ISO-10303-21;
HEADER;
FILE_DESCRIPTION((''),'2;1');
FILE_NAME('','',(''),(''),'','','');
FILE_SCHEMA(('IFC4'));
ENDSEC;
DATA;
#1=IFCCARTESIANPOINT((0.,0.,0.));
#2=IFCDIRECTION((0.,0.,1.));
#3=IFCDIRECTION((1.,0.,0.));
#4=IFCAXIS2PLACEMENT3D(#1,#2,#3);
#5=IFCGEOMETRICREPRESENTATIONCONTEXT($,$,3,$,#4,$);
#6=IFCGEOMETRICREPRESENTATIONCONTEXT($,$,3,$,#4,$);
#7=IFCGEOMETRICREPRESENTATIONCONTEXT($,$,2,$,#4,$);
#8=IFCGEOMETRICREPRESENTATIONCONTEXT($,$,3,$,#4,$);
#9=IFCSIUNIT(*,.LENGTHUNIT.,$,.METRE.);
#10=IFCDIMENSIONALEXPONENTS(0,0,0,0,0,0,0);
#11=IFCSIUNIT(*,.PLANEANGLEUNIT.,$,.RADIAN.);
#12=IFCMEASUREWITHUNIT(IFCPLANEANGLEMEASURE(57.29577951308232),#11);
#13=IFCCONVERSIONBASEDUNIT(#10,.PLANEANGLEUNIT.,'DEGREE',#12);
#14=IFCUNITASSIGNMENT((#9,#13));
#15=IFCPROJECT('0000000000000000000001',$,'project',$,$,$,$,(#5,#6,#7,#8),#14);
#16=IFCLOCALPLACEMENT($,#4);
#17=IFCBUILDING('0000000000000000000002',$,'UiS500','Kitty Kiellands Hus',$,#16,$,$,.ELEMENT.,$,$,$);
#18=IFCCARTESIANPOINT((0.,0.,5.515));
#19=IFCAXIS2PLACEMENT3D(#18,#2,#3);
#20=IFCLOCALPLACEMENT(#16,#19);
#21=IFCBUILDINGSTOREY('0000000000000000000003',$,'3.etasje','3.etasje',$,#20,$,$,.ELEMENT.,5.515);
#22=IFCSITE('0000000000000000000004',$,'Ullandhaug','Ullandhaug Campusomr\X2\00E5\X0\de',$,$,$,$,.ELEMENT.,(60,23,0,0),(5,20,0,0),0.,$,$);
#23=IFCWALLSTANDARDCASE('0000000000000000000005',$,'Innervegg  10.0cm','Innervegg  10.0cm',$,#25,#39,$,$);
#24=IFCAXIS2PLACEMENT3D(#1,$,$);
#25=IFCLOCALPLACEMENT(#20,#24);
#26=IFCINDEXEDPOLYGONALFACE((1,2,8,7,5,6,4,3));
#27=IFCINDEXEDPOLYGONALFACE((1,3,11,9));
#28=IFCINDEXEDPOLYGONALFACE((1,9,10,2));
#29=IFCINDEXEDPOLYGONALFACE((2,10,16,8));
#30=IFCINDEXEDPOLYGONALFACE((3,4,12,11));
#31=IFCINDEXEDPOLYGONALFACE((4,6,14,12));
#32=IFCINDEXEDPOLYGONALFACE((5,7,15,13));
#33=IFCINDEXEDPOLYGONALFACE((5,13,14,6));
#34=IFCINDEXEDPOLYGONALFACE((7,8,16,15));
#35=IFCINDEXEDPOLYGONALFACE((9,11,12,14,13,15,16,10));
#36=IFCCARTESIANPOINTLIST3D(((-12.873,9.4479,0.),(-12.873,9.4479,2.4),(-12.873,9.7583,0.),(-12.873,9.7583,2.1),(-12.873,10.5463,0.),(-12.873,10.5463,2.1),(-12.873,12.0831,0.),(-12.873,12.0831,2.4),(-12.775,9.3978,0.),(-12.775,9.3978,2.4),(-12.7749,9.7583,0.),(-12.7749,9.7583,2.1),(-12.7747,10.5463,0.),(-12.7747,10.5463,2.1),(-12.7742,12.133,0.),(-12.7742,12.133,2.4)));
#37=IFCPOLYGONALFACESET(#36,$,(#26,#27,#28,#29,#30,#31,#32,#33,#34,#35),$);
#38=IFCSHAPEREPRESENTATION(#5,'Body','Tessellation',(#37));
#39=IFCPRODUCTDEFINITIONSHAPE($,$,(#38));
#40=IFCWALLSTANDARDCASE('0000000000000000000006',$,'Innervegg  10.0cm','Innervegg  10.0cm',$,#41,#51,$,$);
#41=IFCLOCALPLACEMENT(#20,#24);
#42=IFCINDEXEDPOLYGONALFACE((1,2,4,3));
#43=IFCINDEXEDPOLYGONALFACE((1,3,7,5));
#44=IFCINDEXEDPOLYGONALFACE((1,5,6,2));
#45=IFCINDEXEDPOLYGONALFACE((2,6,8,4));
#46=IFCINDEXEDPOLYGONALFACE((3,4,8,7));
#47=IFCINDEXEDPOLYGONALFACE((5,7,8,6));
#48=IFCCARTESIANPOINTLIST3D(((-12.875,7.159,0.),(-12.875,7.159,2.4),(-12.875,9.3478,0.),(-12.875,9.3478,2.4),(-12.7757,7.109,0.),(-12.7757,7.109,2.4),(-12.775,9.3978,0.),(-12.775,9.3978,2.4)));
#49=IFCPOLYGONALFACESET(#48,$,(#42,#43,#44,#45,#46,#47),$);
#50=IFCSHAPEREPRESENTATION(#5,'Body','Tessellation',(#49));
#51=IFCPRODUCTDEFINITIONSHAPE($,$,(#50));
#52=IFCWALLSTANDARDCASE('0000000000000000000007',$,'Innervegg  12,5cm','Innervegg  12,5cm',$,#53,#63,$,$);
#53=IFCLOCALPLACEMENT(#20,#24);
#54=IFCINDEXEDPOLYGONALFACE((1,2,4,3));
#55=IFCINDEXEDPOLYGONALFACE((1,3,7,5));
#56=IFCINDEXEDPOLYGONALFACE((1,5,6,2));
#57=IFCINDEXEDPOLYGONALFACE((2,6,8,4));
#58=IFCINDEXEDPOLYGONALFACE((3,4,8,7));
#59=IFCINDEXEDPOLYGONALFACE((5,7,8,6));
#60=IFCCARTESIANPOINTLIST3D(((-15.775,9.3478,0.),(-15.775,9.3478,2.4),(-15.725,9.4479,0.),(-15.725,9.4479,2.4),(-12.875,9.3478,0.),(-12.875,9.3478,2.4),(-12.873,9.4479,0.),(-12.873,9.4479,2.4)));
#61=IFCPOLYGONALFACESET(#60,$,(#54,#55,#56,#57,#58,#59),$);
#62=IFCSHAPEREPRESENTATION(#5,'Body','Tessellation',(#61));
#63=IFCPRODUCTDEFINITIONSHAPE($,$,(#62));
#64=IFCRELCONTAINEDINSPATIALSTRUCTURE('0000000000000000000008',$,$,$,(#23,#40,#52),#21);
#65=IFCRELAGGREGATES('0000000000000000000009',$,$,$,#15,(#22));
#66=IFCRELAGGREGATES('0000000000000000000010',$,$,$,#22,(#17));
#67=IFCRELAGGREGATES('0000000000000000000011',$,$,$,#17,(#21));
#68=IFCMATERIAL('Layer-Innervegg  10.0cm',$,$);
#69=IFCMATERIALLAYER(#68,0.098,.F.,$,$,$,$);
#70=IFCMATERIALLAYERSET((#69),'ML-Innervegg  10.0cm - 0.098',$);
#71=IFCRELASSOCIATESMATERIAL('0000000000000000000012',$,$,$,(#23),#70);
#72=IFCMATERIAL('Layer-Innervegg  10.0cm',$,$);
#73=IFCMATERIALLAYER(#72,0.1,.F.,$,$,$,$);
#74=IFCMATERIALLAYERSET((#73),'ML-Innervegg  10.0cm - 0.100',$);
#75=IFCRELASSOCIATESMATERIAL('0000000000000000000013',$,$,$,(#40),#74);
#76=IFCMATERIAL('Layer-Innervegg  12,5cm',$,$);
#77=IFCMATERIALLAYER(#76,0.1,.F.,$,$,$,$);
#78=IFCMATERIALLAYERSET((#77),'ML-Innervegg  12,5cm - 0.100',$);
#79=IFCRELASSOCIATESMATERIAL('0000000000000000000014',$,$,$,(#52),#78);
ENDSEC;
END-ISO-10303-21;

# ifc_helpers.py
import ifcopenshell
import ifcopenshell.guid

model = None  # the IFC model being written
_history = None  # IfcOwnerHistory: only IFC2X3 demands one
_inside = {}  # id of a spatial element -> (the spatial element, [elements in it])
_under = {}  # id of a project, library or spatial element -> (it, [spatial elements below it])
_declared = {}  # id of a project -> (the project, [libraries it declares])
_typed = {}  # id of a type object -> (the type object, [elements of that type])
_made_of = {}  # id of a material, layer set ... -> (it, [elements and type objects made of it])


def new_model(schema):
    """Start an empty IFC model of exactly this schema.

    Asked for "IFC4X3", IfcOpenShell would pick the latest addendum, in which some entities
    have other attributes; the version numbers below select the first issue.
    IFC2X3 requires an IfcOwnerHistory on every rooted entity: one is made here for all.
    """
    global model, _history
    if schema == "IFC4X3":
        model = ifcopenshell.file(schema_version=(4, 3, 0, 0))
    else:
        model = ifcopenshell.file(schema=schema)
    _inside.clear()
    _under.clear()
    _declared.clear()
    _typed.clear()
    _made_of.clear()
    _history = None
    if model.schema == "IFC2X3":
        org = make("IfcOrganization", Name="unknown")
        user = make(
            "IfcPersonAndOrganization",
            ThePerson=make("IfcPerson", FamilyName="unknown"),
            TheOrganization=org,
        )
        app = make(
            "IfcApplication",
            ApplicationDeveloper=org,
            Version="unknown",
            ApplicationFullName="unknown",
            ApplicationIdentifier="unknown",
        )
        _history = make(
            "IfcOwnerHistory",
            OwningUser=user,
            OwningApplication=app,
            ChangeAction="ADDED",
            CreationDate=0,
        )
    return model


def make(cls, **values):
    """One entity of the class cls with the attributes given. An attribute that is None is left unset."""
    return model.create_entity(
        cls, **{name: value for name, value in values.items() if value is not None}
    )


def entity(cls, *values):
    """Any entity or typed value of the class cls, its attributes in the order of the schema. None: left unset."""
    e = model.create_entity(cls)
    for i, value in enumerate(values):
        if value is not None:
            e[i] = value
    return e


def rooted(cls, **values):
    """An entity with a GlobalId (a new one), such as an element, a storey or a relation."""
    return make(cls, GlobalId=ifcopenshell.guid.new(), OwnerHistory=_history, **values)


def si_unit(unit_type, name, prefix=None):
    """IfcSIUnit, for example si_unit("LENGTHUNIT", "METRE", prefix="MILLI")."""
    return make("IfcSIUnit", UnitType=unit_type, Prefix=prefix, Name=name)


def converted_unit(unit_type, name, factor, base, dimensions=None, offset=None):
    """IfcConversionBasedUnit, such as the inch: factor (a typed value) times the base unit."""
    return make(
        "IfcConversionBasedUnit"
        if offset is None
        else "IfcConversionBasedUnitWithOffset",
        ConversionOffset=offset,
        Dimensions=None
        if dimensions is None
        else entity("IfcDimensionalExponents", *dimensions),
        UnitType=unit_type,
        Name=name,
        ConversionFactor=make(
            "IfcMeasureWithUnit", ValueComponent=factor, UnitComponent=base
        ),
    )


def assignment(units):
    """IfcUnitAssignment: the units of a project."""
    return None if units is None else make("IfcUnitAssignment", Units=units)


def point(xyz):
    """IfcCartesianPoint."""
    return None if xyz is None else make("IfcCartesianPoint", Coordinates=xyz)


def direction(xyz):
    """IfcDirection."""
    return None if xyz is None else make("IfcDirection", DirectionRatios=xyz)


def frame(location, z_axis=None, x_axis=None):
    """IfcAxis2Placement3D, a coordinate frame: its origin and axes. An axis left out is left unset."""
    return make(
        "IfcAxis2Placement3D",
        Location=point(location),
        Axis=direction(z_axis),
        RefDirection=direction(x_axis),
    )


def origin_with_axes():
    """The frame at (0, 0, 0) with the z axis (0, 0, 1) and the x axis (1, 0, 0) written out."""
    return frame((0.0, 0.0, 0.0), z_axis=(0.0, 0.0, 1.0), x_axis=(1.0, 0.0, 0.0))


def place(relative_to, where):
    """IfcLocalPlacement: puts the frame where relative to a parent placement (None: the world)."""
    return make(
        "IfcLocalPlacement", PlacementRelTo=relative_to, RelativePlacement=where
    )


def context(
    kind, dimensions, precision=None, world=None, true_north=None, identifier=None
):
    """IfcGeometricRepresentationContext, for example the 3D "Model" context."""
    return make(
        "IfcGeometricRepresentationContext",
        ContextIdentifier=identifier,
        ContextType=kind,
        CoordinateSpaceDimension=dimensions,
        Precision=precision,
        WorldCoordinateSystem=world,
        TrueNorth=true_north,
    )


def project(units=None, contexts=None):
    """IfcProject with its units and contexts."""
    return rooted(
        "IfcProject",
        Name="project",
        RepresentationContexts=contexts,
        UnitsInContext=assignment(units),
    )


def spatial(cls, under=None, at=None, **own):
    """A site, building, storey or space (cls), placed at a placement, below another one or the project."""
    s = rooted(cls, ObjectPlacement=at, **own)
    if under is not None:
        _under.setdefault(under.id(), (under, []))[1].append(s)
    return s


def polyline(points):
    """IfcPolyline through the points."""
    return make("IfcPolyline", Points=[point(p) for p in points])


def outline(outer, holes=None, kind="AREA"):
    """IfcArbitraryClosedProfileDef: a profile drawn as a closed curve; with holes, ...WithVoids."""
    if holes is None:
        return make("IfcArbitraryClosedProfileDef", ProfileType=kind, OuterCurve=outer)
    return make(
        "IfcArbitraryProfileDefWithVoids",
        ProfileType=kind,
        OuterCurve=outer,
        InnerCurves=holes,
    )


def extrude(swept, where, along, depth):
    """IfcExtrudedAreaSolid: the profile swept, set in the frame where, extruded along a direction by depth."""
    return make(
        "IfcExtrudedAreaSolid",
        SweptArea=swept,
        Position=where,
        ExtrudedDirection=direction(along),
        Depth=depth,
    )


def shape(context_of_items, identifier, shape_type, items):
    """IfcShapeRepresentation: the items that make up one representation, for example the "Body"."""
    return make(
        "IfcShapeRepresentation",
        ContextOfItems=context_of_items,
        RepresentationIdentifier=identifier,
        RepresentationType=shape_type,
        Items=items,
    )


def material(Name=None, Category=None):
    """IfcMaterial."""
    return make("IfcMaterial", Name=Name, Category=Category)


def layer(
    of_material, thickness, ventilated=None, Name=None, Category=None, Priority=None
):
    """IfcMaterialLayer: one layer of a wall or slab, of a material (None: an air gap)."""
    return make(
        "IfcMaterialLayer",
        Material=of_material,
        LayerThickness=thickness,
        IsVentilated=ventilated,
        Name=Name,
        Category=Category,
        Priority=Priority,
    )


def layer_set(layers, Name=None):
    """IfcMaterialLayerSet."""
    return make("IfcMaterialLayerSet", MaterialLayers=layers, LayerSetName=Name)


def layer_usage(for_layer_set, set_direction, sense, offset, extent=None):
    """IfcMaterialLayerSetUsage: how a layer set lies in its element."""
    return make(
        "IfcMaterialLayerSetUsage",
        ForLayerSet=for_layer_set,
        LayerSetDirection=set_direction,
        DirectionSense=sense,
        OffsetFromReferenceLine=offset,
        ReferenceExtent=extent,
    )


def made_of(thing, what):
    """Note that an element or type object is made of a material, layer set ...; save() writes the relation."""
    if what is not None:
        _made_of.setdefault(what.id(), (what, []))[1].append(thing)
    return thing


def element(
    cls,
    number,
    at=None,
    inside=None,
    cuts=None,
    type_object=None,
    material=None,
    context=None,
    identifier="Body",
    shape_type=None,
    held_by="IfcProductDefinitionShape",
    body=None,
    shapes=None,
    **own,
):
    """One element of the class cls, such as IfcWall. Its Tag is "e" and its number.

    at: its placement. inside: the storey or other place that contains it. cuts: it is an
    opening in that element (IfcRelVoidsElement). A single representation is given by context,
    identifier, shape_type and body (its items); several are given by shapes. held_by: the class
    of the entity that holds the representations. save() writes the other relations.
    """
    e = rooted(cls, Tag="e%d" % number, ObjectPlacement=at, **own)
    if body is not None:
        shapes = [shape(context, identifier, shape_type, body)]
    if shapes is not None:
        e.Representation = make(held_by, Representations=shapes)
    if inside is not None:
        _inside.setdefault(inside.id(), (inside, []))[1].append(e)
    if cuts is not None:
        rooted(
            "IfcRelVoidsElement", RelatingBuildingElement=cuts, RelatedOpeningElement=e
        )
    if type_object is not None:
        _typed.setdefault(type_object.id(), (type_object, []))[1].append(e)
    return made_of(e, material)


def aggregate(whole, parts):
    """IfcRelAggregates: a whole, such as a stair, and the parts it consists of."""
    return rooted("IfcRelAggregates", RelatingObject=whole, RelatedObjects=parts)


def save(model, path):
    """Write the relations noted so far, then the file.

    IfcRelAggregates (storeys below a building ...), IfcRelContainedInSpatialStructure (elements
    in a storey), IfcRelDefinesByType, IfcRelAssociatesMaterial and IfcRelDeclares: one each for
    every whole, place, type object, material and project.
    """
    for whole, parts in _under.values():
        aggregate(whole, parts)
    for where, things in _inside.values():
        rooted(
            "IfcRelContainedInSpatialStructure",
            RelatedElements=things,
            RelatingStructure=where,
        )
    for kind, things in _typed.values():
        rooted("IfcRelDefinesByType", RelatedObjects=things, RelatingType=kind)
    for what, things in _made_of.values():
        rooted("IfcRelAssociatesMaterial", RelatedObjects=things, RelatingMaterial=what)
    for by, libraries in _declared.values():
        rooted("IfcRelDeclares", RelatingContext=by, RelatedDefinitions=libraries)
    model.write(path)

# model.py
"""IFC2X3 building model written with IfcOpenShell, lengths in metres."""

from ifc_helpers import new_model, entity, si_unit, converted_unit, frame, origin_with_axes, place, context, project, spatial, polyline, outline, extrude, material, layer, layer_set, layer_usage, element, save


model = new_model("IFC2X3")

# Units and contexts
context_of_model_1 = context(None, 3, world=origin_with_axes())
context_of_model_2 = context(None, 3, world=origin_with_axes())
context_of_model_3 = context(None, 2, world=origin_with_axes())
context_of_model_4 = context(None, 3, world=origin_with_axes())
ifc_project = project(units=[si_unit("LENGTHUNIT", "METRE"), converted_unit("PLANEANGLEUNIT", "DEGREE", entity("IfcPlaneAngleMeasure", 57.29577951308232), si_unit("PLANEANGLEUNIT", "RADIAN"), dimensions=[0, 0, 0, 0, 0, 0, 0])], contexts=[context_of_model_1, context_of_model_2, context_of_model_3, context_of_model_4])

# Site, building, storey
site = spatial("IfcSite", under=ifc_project, Name="Ullandhaug", Description="Ullandhaug Campusområde", CompositionType="ELEMENT", RefLatitude=(60, 23, 0, 0), RefLongitude=(5, 20, 0, 0), RefElevation=0.0)
building_placement = place(None, origin_with_axes())
building = spatial("IfcBuilding", under=site, at=building_placement, Name="UiS500", Description="Kitty Kiellands Hus", CompositionType="ELEMENT")
storey_placement = place(building_placement, frame((0.0, 0.0, 5.515), z_axis=(0.0, 0.0, 1.0), x_axis=(1.0, 0.0, 0.0)))
storey = spatial("IfcBuildingStorey", under=building, at=storey_placement, Name="3.etasje", Description="3.etasje", CompositionType="ELEMENT", Elevation=5.515)

# Shared definitions
ifc_material_1 = material(Name="Layer-Innervegg  10.0cm")
ifc_layer_1 = layer(ifc_material_1, 0.1, ventilated=False)
ifc_layer_set_1 = layer_set([ifc_layer_1], Name="ML-Innervegg  10.0cm - 0.100")
ifc_layer_usage_1 = layer_usage(ifc_layer_set_1, "AXIS2", "POSITIVE", 0.0)

# Shared definitions
ifc_material_2 = material(Name="Layer-Innervegg  12,5cm")
ifc_layer_2 = layer(ifc_material_2, 0.1, ventilated=False)
ifc_layer_set_2 = layer_set([ifc_layer_2], Name="ML-Innervegg  12,5cm - 0.100")
ifc_layer_usage_2 = layer_usage(ifc_layer_set_2, "AXIS2", "POSITIVE", 0.0)

# Wall, opening
ifc_material_3 = material(Name="Layer-Innervegg  10.0cm")
ifc_layer_3 = layer(ifc_material_3, 0.098, ventilated=False)
ifc_layer_set_3 = layer_set([ifc_layer_3], Name="ML-Innervegg  10.0cm - 0.098")
ifc_layer_usage_3 = layer_usage(ifc_layer_set_3, "AXIS2", "POSITIVE", 0.0)
wall_1_placement = place(storey_placement, frame((-12.873, 12.0831, 0.0), z_axis=(0.0, 0.0, 1.0), x_axis=(0.0, -1.0, 0.0)))
wall_1 = element("IfcWallStandardCase", 1, at=wall_1_placement, inside=storey, material=ifc_layer_usage_3, Name="Innervegg  10.0cm", Description="Innervegg  10.0cm", context=context_of_model_1, shape_type="SweptSolid", body=[
    extrude(outline(polyline([(0.0, 0.0), (2.6351, 0.0), (2.6852, 0.0979), (-0.05, 0.0988), (0.0, 0.0)])), frame((0.0, 0.0, 0.0), z_axis=(0.0, 0.0, 1.0), x_axis=(1.0, 0.0, 0.0)), (0.0, 0.0, 1.0), 2.4),
])
opening_1_placement = place(wall_1_placement, frame((1.5368, 0.0983, 0.0), z_axis=(0.0, 0.0, 1.0), x_axis=(1.0, 0.0, 0.0)))
element("IfcOpeningElement", 2, at=opening_1_placement, cuts=wall_1, context=context_of_model_1, shape_type="SweptSolid", body=[
    extrude(outline(polyline([(0.0, 0.0), (2.1, 0.0), (2.1, 0.788), (0.0, 0.788), (0.0, 0.0)])), frame((0.0, 0.0, 0.0), z_axis=(0.0003, 1.0, 0.0), x_axis=(0.0, 0.0, 1.0)), (0.0, 0.0003, -1.0), 0.0984),
])

# Walls
wall_2_placement = place(storey_placement, frame((-12.875, 9.3478, 0.0), z_axis=(0.0, 0.0, 1.0), x_axis=(0.0, -1.0, 0.0)))
element("IfcWallStandardCase", 3, at=wall_2_placement, inside=storey, material=ifc_layer_usage_1, Name="Innervegg  10.0cm", Description="Innervegg  10.0cm", context=context_of_model_1, shape_type="SweptSolid", body=[
    extrude(outline(polyline([(0.0, 0.0), (2.1888, 0.0), (2.2388, 0.0993), (-0.0501, 0.1), (0.0, 0.0)])), frame((0.0, 0.0, 0.0), z_axis=(0.0, 0.0, 1.0), x_axis=(1.0, 0.0, 0.0)), (0.0, 0.0, 1.0), 2.4),
])
wall_3_placement = place(storey_placement, frame((-12.873, 9.4479, 0.0), z_axis=(0.0, 0.0, 1.0), x_axis=(-1.0, 0.0, 0.0)))
element("IfcWallStandardCase", 4, at=wall_3_placement, inside=storey, material=ifc_layer_usage_2, Name="Innervegg  12,5cm", Description="Innervegg  12,5cm", context=context_of_model_1, shape_type="SweptSolid", body=[
    extrude(outline(polyline([(0.0, 0.0), (2.852, 0.0), (2.902, 0.1002), (0.0021, 0.1002), (0.0, 0.0)])), frame((0.0, 0.0, 0.0), z_axis=(0.0, 0.0, 1.0), x_axis=(1.0, 0.0, 0.0)), (0.0, 0.0, 1.0), 2.4),
])

save(model, "model.ifc")
